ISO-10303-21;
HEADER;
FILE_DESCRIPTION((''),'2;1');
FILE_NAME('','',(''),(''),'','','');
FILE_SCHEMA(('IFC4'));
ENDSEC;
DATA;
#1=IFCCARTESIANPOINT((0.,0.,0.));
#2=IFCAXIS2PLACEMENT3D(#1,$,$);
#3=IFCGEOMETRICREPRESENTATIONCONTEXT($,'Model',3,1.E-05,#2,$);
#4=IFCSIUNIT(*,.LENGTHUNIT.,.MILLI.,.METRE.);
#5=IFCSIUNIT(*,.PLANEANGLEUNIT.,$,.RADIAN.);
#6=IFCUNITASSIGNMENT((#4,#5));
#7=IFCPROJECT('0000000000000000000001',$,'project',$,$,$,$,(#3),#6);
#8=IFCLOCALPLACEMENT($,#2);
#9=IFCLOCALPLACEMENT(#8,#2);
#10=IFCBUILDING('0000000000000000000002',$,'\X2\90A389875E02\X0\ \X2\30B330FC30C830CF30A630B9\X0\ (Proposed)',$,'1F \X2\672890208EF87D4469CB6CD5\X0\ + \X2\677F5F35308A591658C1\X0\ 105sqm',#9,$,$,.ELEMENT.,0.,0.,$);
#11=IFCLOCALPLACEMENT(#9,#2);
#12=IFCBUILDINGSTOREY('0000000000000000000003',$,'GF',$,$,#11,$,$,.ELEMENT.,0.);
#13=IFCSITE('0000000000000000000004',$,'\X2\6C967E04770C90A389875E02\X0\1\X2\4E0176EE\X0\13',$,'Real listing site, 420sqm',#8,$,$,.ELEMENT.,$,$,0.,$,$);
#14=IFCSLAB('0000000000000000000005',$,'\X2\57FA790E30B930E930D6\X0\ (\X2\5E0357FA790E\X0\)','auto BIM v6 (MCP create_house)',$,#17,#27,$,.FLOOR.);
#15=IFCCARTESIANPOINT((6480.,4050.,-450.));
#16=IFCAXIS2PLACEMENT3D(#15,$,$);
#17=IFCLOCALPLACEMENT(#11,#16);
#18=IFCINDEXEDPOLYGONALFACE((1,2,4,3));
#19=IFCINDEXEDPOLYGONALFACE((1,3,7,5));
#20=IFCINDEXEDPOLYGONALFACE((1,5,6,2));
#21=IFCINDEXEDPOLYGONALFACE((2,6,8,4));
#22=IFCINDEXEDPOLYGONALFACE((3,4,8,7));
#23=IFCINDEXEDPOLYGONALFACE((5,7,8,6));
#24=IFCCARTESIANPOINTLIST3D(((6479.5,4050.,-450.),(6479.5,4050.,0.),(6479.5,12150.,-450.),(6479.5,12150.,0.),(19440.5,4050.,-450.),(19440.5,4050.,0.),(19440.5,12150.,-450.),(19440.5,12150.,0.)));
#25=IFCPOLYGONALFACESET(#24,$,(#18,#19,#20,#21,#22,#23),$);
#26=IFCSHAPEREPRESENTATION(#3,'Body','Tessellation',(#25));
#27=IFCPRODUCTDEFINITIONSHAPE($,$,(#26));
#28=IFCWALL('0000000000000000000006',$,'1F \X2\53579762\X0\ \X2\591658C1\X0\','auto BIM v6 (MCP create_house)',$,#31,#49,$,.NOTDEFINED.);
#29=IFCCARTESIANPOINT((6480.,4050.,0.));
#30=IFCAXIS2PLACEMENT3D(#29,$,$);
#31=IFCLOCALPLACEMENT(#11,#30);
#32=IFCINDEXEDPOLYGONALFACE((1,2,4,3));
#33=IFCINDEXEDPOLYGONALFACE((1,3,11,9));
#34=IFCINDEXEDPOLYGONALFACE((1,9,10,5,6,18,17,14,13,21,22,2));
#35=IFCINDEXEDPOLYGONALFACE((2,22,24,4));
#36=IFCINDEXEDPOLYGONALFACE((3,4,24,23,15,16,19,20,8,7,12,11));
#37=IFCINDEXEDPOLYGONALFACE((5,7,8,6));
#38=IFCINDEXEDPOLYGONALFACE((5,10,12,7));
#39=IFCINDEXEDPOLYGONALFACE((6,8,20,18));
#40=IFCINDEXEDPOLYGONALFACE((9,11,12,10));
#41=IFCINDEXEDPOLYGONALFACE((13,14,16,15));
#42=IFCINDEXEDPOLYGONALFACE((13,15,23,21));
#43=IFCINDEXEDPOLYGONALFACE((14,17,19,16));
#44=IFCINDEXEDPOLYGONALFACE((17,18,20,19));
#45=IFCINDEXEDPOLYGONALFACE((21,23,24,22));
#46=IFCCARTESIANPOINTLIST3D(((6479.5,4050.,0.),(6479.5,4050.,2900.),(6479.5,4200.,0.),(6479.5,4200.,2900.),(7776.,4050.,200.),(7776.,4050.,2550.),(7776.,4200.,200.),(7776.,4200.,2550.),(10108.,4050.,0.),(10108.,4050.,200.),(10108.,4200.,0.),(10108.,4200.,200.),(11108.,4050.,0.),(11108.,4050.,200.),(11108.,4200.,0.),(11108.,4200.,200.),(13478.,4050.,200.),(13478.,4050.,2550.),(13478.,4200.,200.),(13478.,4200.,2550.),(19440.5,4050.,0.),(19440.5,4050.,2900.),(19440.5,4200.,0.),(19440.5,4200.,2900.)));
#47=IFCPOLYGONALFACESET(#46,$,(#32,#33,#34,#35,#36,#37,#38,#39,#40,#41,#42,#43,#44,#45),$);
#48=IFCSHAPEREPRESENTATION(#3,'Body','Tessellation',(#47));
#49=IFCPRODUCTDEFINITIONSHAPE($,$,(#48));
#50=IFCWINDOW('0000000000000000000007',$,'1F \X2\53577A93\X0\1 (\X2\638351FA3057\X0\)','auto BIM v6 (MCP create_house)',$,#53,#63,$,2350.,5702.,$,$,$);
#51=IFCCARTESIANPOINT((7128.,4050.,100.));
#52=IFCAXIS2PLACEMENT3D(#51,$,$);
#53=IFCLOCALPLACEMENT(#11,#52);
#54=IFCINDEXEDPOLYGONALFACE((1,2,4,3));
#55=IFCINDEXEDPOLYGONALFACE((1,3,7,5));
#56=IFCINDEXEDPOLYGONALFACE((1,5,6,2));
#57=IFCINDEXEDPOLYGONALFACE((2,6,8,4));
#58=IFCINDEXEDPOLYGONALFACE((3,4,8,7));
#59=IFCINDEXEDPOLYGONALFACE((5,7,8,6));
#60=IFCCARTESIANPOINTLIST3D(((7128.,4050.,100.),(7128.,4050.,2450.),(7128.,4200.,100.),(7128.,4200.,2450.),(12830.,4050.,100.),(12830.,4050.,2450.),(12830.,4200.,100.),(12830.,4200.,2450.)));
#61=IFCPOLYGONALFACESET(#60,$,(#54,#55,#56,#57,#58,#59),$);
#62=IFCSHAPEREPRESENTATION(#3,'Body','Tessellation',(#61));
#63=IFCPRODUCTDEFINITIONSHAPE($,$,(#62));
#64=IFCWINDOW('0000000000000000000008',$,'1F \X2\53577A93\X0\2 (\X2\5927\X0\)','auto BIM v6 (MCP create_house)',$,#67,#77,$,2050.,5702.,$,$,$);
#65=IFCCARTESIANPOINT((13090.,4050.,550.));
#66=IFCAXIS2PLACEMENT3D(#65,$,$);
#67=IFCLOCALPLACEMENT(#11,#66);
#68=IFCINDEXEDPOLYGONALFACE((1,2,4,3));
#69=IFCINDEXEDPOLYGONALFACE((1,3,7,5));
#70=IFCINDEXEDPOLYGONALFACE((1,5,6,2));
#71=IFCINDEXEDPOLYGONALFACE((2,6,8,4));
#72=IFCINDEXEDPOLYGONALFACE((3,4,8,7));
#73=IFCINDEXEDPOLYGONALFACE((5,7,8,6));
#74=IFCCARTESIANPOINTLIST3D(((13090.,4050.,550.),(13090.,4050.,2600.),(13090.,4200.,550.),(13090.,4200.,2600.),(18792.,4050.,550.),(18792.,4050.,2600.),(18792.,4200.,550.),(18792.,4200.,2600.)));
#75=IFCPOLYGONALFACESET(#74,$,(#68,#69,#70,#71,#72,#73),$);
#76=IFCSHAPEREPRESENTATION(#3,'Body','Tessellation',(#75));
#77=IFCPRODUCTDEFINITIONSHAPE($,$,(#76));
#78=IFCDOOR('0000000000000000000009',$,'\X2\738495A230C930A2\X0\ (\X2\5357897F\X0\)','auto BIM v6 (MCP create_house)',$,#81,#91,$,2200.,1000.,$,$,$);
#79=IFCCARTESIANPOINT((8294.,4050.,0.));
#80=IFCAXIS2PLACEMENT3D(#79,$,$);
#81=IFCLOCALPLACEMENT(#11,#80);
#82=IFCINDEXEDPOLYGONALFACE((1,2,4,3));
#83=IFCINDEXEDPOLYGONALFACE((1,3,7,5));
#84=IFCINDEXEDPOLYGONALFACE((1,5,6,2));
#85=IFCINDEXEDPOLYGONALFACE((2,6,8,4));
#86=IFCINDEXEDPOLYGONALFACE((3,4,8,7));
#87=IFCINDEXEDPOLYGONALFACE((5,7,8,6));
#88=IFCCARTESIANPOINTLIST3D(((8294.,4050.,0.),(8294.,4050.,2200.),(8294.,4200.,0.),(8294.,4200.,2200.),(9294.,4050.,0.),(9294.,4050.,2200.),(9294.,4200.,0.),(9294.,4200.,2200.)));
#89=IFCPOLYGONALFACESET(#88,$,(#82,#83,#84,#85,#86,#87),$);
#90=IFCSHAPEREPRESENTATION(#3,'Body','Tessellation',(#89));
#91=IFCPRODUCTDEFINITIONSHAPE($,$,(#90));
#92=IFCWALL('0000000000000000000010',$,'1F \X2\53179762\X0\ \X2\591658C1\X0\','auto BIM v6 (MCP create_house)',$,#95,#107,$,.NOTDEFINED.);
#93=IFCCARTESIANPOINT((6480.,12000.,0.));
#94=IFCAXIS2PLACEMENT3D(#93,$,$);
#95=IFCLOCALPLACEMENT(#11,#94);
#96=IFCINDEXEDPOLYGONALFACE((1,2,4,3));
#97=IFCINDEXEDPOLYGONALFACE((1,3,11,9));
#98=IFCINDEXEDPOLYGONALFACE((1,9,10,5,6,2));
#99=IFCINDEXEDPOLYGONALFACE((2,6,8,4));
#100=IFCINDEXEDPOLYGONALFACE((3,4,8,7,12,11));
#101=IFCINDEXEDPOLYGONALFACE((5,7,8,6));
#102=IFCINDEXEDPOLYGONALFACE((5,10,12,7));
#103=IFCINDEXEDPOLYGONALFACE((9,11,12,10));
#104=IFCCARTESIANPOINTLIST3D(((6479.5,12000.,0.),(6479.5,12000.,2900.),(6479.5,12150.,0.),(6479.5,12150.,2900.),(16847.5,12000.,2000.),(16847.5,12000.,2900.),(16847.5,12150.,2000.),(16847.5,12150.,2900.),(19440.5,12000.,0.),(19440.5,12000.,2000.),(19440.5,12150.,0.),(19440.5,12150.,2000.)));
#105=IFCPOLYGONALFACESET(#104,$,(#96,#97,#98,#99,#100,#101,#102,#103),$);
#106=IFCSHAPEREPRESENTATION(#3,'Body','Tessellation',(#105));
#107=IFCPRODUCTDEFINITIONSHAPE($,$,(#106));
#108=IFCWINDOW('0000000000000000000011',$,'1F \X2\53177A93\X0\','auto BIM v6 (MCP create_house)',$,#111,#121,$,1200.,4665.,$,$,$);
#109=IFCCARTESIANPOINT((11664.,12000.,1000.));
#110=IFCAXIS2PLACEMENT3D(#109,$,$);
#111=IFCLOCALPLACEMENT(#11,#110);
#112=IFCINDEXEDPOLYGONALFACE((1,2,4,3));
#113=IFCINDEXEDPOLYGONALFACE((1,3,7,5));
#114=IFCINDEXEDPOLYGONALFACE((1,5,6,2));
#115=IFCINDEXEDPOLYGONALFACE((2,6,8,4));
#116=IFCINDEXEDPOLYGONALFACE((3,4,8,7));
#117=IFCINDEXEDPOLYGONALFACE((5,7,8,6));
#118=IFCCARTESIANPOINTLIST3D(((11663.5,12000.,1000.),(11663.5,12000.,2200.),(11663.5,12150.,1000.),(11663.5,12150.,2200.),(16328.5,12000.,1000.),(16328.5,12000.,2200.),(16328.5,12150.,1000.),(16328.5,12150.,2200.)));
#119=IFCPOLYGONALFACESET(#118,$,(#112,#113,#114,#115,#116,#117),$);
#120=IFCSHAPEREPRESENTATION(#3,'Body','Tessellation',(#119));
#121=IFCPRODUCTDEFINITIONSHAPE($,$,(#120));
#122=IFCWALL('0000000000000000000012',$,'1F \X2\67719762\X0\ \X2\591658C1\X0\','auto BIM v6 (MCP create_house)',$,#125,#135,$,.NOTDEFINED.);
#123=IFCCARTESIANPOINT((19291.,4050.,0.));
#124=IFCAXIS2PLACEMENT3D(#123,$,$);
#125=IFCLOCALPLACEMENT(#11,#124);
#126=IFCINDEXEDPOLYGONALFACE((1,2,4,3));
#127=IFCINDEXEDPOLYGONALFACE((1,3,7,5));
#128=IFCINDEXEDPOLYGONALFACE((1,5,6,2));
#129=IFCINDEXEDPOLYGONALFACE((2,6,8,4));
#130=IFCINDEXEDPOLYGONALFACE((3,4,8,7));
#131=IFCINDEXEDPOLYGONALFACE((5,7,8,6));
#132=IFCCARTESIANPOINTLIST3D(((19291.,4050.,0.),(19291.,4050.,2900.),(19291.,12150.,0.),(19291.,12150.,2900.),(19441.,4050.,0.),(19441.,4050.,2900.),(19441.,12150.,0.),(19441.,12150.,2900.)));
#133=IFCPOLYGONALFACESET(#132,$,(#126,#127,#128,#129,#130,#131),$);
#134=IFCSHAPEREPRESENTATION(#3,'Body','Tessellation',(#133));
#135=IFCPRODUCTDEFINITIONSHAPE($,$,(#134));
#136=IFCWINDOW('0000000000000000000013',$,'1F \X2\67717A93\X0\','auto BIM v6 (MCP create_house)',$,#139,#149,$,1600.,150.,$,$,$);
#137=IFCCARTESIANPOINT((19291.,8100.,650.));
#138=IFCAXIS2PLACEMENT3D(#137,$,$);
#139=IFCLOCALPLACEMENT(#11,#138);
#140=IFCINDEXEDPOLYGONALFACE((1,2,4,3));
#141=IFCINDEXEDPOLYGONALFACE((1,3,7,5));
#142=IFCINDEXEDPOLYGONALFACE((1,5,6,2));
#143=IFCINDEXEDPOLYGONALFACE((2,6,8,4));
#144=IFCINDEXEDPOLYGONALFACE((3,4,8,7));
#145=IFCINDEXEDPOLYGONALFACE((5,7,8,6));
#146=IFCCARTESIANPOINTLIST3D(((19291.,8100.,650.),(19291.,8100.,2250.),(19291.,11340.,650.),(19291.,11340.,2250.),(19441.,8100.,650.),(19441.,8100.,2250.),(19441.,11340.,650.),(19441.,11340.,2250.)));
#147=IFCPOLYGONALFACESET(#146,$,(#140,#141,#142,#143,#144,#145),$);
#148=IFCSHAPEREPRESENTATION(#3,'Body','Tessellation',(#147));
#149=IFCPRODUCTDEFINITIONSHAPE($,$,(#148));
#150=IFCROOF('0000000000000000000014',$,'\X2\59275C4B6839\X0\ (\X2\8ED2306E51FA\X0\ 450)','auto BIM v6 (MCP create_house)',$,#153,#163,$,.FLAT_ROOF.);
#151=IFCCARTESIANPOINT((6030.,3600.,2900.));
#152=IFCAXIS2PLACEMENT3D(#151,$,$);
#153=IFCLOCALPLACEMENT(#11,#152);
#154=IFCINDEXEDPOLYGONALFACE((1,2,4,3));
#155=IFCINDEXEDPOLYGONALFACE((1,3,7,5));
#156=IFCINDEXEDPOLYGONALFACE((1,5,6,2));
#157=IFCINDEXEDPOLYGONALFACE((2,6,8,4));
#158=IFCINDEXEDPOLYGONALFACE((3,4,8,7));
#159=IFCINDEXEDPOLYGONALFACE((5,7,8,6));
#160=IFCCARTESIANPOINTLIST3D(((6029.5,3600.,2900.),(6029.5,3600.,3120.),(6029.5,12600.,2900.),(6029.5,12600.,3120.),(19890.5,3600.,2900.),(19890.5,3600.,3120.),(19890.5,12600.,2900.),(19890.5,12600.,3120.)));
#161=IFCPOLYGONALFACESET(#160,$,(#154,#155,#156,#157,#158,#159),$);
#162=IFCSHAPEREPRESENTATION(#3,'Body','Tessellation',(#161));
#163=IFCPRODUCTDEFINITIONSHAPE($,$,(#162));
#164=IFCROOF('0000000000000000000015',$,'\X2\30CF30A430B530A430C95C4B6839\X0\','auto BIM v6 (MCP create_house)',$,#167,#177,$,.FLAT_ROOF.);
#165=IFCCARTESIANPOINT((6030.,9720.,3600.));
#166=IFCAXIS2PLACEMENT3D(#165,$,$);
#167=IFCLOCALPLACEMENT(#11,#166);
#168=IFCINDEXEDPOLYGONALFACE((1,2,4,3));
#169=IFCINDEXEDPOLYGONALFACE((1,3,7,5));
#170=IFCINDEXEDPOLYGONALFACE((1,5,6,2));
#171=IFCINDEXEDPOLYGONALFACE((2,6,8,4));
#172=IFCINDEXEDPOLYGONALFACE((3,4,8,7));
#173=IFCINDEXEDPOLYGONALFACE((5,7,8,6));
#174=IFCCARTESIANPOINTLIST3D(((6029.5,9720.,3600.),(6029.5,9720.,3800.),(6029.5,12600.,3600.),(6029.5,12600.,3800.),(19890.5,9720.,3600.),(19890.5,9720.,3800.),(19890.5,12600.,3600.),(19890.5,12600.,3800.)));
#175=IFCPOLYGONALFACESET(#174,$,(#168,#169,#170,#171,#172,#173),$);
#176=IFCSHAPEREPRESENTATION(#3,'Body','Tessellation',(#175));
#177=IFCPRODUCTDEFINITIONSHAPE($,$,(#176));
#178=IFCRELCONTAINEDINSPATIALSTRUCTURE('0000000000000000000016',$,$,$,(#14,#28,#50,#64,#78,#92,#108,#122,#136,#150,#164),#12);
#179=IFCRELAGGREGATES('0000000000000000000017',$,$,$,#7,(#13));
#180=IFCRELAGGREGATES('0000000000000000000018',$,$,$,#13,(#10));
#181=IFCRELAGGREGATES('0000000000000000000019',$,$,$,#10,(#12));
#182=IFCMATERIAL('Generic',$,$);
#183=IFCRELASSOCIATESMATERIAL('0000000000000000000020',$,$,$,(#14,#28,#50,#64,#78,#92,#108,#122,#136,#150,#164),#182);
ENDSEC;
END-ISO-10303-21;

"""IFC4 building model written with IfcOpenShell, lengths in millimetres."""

from ifc_helpers import new_model, si_unit, frame, frame_2d, origin, place, context, project, spatial, rectangle, extrude, material, element, fill, save


model = new_model("IFC4")

# Units and contexts
model_context = context("Model", 3, precision=1e-05, world=origin())
ifc_project = project(units=[si_unit("LENGTHUNIT", "METRE", prefix="MILLI"), si_unit("PLANEANGLEUNIT", "RADIAN")], contexts=[model_context])

# Site, building, storey
site_placement = place(None, origin())
site = spatial("IfcSite", under=ifc_project, at=site_placement, Name="沖縄県那覇市1丁目13", ObjectType="Real listing site, 420sqm", CompositionType="ELEMENT", RefElevation=0.0)
building_placement = place(site_placement, origin())
building = spatial("IfcBuilding", under=site, at=building_placement, Name="那覇市 コートハウス (Proposed)", ObjectType="1F 木造軸組構法 + 板張り外壁 105sqm", CompositionType="ELEMENT", ElevationOfRefHeight=0.0, ElevationOfTerrain=0.0)
storey_placement = place(building_placement, origin())
storey = spatial("IfcBuildingStorey", under=building, at=storey_placement, Name="GF", CompositionType="ELEMENT", Elevation=0.0)

# Slab
ifc_material = material(Name="Generic")
slab_1_placement = place(storey_placement, frame((6480.0, 4050.0, -450.0)))
element("IfcSlab", 1, at=slab_1_placement, inside=storey, material=ifc_material, Name="基礎スラブ (布基礎)", Description="auto BIM v6 (MCP create_house)", PredefinedType="FLOOR", context=model_context, shape_type="SweptSolid", body=[
    extrude(rectangle(XDim=12961.0, YDim=8100.0, at=frame_2d((6480.0, 4050.0))), frame((6480.0, 4050.0, -450.0)), (0.0, 0.0, 1.0), 450.0),
])

# Wall, openings, windows, door
wall_1_placement = place(storey_placement, frame((6480.0, 4050.0, 0.0)))
wall_1 = element("IfcWall", 2, at=wall_1_placement, inside=storey, material=ifc_material, Name="1F 南面 外壁", Description="auto BIM v6 (MCP create_house)", PredefinedType="NOTDEFINED", context=model_context, shape_type="SweptSolid", body=[
    extrude(rectangle(XDim=12961.0, YDim=150.0, at=frame_2d((6480.0, 75.0))), frame((6480.0, 4050.0, 0.0)), (0.0, 0.0, 1.0), 2900.0),
])
opening_1_placement = place(storey_placement, frame((7128.0, 4050.0, 100.0)))
opening_1 = element("IfcOpeningElement", 3, at=opening_1_placement, cuts=wall_1, PredefinedType="NOTDEFINED", context=model_context, shape_type="SweptSolid", body=[
    extrude(rectangle(XDim=5702.0, YDim=150.0, at=frame_2d((2851.0, 75.0))), frame((7128.0, 4050.0, 100.0)), (0.0, 0.0, 1.0), 2350.0),
])
opening_2_placement = place(storey_placement, frame((13090.0, 4050.0, 550.0)))
opening_2 = element("IfcOpeningElement", 4, at=opening_2_placement, cuts=wall_1, PredefinedType="NOTDEFINED", context=model_context, shape_type="SweptSolid", body=[
    extrude(rectangle(XDim=5702.0, YDim=150.0, at=frame_2d((2851.0, 75.0))), frame((13090.0, 4050.0, 550.0)), (0.0, 0.0, 1.0), 2050.0),
])
opening_3_placement = place(storey_placement, frame((8294.0, 4050.0, 0.0)))
opening_3 = element("IfcOpeningElement", 5, at=opening_3_placement, cuts=wall_1, PredefinedType="NOTDEFINED", context=model_context, shape_type="SweptSolid", body=[
    extrude(rectangle(XDim=1000.0, YDim=150.0, at=frame_2d((500.0, 75.0))), frame((8294.0, 4050.0, 0.0)), (0.0, 0.0, 1.0), 2200.0),
])
window_1_placement = place(storey_placement, frame((7128.0, 4050.0, 100.0)))
window_1 = element("IfcWindow", 6, at=window_1_placement, inside=storey, material=ifc_material, Name="1F 南窓1 (掃出し)", Description="auto BIM v6 (MCP create_house)", OverallHeight=2350.0, OverallWidth=5702.0, context=model_context, shape_type="SweptSolid", body=[
    extrude(rectangle(XDim=5702.0, YDim=150.0, at=frame_2d((2851.0, 75.0))), frame((7128.0, 4050.0, 100.0)), (0.0, 0.0, 1.0), 2350.0),
])
fill(opening_1, window_1)
window_2_placement = place(storey_placement, frame((13090.0, 4050.0, 550.0)))
window_2 = element("IfcWindow", 7, at=window_2_placement, inside=storey, material=ifc_material, Name="1F 南窓2 (大)", Description="auto BIM v6 (MCP create_house)", OverallHeight=2050.0, OverallWidth=5702.0, context=model_context, shape_type="SweptSolid", body=[
    extrude(rectangle(XDim=5702.0, YDim=150.0, at=frame_2d((2851.0, 75.0))), frame((13090.0, 4050.0, 550.0)), (0.0, 0.0, 1.0), 2050.0),
])
fill(opening_2, window_2)
door_placement = place(storey_placement, frame((8294.0, 4050.0, 0.0)))
door = element("IfcDoor", 8, at=door_placement, inside=storey, material=ifc_material, Name="玄関ドア (南西)", Description="auto BIM v6 (MCP create_house)", OverallHeight=2200.0, OverallWidth=1000.0, context=model_context, shape_type="SweptSolid", body=[
    extrude(rectangle(XDim=1000.0, YDim=150.0, at=frame_2d((500.0, 75.0))), frame((8294.0, 4050.0, 0.0)), (0.0, 0.0, 1.0), 2200.0),
])
fill(opening_3, door)

# Walls, openings, windows
wall_2_placement = place(storey_placement, frame((6480.0, 12000.0, 0.0)))
wall_2 = element("IfcWall", 9, at=wall_2_placement, inside=storey, material=ifc_material, Name="1F 北面 外壁", Description="auto BIM v6 (MCP create_house)", PredefinedType="NOTDEFINED", context=model_context, shape_type="SweptSolid", body=[
    extrude(rectangle(XDim=12961.0, YDim=150.0, at=frame_2d((6480.0, 75.0))), frame((6480.0, 12000.0, 0.0)), (0.0, 0.0, 1.0), 2900.0),
])
opening_4_placement = place(storey_placement, frame((11664.0, 12000.0, 1000.0)))
opening_4 = element("IfcOpeningElement", 10, at=opening_4_placement, cuts=wall_2, PredefinedType="NOTDEFINED", context=model_context, shape_type="SweptSolid", body=[
    extrude(rectangle(XDim=4665.0, YDim=150.0, at=frame_2d((2332.0, 75.0))), frame((11664.0, 12000.0, 1000.0)), (0.0, 0.0, 1.0), 1200.0),
])
window_3_placement = place(storey_placement, frame((11664.0, 12000.0, 1000.0)))
window_3 = element("IfcWindow", 11, at=window_3_placement, inside=storey, material=ifc_material, Name="1F 北窓", Description="auto BIM v6 (MCP create_house)", OverallHeight=1200.0, OverallWidth=4665.0, context=model_context, shape_type="SweptSolid", body=[
    extrude(rectangle(XDim=4665.0, YDim=150.0, at=frame_2d((2332.0, 75.0))), frame((11664.0, 12000.0, 1000.0)), (0.0, 0.0, 1.0), 1200.0),
])
fill(opening_4, window_3)
wall_3_placement = place(storey_placement, frame((19291.0, 4050.0, 0.0)))
wall_3 = element("IfcWall", 12, at=wall_3_placement, inside=storey, material=ifc_material, Name="1F 東面 外壁", Description="auto BIM v6 (MCP create_house)", PredefinedType="NOTDEFINED", context=model_context, shape_type="SweptSolid", body=[
    extrude(rectangle(XDim=150.0, YDim=8100.0, at=frame_2d((75.0, 4050.0))), frame((19291.0, 4050.0, 0.0)), (0.0, 0.0, 1.0), 2900.0),
])
opening_5_placement = place(storey_placement, frame((19291.0, 8100.0, 650.0)))
opening_5 = element("IfcOpeningElement", 13, at=opening_5_placement, cuts=wall_3, PredefinedType="NOTDEFINED", context=model_context, shape_type="SweptSolid", body=[
    extrude(rectangle(XDim=150.0, YDim=3240.0, at=frame_2d((75.0, 1620.0))), frame((19291.0, 8100.0, 650.0)), (0.0, 0.0, 1.0), 1600.0),
])
window_4_placement = place(storey_placement, frame((19291.0, 8100.0, 650.0)))
window_4 = element("IfcWindow", 14, at=window_4_placement, inside=storey, material=ifc_material, Name="1F 東窓", Description="auto BIM v6 (MCP create_house)", OverallHeight=1600.0, OverallWidth=150.0, context=model_context, shape_type="SweptSolid", body=[
    extrude(rectangle(XDim=150.0, YDim=3240.0, at=frame_2d((75.0, 1620.0))), frame((19291.0, 8100.0, 650.0)), (0.0, 0.0, 1.0), 1600.0),
])
fill(opening_5, window_4)

# Roofs
roof_1_placement = place(storey_placement, frame((6030.0, 3600.0, 2900.0)))
element("IfcRoof", 15, at=roof_1_placement, inside=storey, material=ifc_material, Name="大屋根 (軒の出 450)", Description="auto BIM v6 (MCP create_house)", PredefinedType="FLAT_ROOF", context=model_context, shape_type="SweptSolid", body=[
    extrude(rectangle(XDim=13861.0, YDim=9000.0, at=frame_2d((6930.0, 4500.0))), frame((6030.0, 3600.0, 2900.0)), (0.0, 0.0, 1.0), 220.0),
])
roof_2_placement = place(storey_placement, frame((6030.0, 9720.0, 3600.0)))
element("IfcRoof", 16, at=roof_2_placement, inside=storey, material=ifc_material, Name="ハイサイド屋根", Description="auto BIM v6 (MCP create_house)", PredefinedType="FLAT_ROOF", context=model_context, shape_type="SweptSolid", body=[
    extrude(rectangle(XDim=13861.0, YDim=2880.0, at=frame_2d((6930.0, 1440.0))), frame((6030.0, 9720.0, 3600.0)), (0.0, 0.0, 1.0), 200.0),
])

save(model, "model.ifc")
